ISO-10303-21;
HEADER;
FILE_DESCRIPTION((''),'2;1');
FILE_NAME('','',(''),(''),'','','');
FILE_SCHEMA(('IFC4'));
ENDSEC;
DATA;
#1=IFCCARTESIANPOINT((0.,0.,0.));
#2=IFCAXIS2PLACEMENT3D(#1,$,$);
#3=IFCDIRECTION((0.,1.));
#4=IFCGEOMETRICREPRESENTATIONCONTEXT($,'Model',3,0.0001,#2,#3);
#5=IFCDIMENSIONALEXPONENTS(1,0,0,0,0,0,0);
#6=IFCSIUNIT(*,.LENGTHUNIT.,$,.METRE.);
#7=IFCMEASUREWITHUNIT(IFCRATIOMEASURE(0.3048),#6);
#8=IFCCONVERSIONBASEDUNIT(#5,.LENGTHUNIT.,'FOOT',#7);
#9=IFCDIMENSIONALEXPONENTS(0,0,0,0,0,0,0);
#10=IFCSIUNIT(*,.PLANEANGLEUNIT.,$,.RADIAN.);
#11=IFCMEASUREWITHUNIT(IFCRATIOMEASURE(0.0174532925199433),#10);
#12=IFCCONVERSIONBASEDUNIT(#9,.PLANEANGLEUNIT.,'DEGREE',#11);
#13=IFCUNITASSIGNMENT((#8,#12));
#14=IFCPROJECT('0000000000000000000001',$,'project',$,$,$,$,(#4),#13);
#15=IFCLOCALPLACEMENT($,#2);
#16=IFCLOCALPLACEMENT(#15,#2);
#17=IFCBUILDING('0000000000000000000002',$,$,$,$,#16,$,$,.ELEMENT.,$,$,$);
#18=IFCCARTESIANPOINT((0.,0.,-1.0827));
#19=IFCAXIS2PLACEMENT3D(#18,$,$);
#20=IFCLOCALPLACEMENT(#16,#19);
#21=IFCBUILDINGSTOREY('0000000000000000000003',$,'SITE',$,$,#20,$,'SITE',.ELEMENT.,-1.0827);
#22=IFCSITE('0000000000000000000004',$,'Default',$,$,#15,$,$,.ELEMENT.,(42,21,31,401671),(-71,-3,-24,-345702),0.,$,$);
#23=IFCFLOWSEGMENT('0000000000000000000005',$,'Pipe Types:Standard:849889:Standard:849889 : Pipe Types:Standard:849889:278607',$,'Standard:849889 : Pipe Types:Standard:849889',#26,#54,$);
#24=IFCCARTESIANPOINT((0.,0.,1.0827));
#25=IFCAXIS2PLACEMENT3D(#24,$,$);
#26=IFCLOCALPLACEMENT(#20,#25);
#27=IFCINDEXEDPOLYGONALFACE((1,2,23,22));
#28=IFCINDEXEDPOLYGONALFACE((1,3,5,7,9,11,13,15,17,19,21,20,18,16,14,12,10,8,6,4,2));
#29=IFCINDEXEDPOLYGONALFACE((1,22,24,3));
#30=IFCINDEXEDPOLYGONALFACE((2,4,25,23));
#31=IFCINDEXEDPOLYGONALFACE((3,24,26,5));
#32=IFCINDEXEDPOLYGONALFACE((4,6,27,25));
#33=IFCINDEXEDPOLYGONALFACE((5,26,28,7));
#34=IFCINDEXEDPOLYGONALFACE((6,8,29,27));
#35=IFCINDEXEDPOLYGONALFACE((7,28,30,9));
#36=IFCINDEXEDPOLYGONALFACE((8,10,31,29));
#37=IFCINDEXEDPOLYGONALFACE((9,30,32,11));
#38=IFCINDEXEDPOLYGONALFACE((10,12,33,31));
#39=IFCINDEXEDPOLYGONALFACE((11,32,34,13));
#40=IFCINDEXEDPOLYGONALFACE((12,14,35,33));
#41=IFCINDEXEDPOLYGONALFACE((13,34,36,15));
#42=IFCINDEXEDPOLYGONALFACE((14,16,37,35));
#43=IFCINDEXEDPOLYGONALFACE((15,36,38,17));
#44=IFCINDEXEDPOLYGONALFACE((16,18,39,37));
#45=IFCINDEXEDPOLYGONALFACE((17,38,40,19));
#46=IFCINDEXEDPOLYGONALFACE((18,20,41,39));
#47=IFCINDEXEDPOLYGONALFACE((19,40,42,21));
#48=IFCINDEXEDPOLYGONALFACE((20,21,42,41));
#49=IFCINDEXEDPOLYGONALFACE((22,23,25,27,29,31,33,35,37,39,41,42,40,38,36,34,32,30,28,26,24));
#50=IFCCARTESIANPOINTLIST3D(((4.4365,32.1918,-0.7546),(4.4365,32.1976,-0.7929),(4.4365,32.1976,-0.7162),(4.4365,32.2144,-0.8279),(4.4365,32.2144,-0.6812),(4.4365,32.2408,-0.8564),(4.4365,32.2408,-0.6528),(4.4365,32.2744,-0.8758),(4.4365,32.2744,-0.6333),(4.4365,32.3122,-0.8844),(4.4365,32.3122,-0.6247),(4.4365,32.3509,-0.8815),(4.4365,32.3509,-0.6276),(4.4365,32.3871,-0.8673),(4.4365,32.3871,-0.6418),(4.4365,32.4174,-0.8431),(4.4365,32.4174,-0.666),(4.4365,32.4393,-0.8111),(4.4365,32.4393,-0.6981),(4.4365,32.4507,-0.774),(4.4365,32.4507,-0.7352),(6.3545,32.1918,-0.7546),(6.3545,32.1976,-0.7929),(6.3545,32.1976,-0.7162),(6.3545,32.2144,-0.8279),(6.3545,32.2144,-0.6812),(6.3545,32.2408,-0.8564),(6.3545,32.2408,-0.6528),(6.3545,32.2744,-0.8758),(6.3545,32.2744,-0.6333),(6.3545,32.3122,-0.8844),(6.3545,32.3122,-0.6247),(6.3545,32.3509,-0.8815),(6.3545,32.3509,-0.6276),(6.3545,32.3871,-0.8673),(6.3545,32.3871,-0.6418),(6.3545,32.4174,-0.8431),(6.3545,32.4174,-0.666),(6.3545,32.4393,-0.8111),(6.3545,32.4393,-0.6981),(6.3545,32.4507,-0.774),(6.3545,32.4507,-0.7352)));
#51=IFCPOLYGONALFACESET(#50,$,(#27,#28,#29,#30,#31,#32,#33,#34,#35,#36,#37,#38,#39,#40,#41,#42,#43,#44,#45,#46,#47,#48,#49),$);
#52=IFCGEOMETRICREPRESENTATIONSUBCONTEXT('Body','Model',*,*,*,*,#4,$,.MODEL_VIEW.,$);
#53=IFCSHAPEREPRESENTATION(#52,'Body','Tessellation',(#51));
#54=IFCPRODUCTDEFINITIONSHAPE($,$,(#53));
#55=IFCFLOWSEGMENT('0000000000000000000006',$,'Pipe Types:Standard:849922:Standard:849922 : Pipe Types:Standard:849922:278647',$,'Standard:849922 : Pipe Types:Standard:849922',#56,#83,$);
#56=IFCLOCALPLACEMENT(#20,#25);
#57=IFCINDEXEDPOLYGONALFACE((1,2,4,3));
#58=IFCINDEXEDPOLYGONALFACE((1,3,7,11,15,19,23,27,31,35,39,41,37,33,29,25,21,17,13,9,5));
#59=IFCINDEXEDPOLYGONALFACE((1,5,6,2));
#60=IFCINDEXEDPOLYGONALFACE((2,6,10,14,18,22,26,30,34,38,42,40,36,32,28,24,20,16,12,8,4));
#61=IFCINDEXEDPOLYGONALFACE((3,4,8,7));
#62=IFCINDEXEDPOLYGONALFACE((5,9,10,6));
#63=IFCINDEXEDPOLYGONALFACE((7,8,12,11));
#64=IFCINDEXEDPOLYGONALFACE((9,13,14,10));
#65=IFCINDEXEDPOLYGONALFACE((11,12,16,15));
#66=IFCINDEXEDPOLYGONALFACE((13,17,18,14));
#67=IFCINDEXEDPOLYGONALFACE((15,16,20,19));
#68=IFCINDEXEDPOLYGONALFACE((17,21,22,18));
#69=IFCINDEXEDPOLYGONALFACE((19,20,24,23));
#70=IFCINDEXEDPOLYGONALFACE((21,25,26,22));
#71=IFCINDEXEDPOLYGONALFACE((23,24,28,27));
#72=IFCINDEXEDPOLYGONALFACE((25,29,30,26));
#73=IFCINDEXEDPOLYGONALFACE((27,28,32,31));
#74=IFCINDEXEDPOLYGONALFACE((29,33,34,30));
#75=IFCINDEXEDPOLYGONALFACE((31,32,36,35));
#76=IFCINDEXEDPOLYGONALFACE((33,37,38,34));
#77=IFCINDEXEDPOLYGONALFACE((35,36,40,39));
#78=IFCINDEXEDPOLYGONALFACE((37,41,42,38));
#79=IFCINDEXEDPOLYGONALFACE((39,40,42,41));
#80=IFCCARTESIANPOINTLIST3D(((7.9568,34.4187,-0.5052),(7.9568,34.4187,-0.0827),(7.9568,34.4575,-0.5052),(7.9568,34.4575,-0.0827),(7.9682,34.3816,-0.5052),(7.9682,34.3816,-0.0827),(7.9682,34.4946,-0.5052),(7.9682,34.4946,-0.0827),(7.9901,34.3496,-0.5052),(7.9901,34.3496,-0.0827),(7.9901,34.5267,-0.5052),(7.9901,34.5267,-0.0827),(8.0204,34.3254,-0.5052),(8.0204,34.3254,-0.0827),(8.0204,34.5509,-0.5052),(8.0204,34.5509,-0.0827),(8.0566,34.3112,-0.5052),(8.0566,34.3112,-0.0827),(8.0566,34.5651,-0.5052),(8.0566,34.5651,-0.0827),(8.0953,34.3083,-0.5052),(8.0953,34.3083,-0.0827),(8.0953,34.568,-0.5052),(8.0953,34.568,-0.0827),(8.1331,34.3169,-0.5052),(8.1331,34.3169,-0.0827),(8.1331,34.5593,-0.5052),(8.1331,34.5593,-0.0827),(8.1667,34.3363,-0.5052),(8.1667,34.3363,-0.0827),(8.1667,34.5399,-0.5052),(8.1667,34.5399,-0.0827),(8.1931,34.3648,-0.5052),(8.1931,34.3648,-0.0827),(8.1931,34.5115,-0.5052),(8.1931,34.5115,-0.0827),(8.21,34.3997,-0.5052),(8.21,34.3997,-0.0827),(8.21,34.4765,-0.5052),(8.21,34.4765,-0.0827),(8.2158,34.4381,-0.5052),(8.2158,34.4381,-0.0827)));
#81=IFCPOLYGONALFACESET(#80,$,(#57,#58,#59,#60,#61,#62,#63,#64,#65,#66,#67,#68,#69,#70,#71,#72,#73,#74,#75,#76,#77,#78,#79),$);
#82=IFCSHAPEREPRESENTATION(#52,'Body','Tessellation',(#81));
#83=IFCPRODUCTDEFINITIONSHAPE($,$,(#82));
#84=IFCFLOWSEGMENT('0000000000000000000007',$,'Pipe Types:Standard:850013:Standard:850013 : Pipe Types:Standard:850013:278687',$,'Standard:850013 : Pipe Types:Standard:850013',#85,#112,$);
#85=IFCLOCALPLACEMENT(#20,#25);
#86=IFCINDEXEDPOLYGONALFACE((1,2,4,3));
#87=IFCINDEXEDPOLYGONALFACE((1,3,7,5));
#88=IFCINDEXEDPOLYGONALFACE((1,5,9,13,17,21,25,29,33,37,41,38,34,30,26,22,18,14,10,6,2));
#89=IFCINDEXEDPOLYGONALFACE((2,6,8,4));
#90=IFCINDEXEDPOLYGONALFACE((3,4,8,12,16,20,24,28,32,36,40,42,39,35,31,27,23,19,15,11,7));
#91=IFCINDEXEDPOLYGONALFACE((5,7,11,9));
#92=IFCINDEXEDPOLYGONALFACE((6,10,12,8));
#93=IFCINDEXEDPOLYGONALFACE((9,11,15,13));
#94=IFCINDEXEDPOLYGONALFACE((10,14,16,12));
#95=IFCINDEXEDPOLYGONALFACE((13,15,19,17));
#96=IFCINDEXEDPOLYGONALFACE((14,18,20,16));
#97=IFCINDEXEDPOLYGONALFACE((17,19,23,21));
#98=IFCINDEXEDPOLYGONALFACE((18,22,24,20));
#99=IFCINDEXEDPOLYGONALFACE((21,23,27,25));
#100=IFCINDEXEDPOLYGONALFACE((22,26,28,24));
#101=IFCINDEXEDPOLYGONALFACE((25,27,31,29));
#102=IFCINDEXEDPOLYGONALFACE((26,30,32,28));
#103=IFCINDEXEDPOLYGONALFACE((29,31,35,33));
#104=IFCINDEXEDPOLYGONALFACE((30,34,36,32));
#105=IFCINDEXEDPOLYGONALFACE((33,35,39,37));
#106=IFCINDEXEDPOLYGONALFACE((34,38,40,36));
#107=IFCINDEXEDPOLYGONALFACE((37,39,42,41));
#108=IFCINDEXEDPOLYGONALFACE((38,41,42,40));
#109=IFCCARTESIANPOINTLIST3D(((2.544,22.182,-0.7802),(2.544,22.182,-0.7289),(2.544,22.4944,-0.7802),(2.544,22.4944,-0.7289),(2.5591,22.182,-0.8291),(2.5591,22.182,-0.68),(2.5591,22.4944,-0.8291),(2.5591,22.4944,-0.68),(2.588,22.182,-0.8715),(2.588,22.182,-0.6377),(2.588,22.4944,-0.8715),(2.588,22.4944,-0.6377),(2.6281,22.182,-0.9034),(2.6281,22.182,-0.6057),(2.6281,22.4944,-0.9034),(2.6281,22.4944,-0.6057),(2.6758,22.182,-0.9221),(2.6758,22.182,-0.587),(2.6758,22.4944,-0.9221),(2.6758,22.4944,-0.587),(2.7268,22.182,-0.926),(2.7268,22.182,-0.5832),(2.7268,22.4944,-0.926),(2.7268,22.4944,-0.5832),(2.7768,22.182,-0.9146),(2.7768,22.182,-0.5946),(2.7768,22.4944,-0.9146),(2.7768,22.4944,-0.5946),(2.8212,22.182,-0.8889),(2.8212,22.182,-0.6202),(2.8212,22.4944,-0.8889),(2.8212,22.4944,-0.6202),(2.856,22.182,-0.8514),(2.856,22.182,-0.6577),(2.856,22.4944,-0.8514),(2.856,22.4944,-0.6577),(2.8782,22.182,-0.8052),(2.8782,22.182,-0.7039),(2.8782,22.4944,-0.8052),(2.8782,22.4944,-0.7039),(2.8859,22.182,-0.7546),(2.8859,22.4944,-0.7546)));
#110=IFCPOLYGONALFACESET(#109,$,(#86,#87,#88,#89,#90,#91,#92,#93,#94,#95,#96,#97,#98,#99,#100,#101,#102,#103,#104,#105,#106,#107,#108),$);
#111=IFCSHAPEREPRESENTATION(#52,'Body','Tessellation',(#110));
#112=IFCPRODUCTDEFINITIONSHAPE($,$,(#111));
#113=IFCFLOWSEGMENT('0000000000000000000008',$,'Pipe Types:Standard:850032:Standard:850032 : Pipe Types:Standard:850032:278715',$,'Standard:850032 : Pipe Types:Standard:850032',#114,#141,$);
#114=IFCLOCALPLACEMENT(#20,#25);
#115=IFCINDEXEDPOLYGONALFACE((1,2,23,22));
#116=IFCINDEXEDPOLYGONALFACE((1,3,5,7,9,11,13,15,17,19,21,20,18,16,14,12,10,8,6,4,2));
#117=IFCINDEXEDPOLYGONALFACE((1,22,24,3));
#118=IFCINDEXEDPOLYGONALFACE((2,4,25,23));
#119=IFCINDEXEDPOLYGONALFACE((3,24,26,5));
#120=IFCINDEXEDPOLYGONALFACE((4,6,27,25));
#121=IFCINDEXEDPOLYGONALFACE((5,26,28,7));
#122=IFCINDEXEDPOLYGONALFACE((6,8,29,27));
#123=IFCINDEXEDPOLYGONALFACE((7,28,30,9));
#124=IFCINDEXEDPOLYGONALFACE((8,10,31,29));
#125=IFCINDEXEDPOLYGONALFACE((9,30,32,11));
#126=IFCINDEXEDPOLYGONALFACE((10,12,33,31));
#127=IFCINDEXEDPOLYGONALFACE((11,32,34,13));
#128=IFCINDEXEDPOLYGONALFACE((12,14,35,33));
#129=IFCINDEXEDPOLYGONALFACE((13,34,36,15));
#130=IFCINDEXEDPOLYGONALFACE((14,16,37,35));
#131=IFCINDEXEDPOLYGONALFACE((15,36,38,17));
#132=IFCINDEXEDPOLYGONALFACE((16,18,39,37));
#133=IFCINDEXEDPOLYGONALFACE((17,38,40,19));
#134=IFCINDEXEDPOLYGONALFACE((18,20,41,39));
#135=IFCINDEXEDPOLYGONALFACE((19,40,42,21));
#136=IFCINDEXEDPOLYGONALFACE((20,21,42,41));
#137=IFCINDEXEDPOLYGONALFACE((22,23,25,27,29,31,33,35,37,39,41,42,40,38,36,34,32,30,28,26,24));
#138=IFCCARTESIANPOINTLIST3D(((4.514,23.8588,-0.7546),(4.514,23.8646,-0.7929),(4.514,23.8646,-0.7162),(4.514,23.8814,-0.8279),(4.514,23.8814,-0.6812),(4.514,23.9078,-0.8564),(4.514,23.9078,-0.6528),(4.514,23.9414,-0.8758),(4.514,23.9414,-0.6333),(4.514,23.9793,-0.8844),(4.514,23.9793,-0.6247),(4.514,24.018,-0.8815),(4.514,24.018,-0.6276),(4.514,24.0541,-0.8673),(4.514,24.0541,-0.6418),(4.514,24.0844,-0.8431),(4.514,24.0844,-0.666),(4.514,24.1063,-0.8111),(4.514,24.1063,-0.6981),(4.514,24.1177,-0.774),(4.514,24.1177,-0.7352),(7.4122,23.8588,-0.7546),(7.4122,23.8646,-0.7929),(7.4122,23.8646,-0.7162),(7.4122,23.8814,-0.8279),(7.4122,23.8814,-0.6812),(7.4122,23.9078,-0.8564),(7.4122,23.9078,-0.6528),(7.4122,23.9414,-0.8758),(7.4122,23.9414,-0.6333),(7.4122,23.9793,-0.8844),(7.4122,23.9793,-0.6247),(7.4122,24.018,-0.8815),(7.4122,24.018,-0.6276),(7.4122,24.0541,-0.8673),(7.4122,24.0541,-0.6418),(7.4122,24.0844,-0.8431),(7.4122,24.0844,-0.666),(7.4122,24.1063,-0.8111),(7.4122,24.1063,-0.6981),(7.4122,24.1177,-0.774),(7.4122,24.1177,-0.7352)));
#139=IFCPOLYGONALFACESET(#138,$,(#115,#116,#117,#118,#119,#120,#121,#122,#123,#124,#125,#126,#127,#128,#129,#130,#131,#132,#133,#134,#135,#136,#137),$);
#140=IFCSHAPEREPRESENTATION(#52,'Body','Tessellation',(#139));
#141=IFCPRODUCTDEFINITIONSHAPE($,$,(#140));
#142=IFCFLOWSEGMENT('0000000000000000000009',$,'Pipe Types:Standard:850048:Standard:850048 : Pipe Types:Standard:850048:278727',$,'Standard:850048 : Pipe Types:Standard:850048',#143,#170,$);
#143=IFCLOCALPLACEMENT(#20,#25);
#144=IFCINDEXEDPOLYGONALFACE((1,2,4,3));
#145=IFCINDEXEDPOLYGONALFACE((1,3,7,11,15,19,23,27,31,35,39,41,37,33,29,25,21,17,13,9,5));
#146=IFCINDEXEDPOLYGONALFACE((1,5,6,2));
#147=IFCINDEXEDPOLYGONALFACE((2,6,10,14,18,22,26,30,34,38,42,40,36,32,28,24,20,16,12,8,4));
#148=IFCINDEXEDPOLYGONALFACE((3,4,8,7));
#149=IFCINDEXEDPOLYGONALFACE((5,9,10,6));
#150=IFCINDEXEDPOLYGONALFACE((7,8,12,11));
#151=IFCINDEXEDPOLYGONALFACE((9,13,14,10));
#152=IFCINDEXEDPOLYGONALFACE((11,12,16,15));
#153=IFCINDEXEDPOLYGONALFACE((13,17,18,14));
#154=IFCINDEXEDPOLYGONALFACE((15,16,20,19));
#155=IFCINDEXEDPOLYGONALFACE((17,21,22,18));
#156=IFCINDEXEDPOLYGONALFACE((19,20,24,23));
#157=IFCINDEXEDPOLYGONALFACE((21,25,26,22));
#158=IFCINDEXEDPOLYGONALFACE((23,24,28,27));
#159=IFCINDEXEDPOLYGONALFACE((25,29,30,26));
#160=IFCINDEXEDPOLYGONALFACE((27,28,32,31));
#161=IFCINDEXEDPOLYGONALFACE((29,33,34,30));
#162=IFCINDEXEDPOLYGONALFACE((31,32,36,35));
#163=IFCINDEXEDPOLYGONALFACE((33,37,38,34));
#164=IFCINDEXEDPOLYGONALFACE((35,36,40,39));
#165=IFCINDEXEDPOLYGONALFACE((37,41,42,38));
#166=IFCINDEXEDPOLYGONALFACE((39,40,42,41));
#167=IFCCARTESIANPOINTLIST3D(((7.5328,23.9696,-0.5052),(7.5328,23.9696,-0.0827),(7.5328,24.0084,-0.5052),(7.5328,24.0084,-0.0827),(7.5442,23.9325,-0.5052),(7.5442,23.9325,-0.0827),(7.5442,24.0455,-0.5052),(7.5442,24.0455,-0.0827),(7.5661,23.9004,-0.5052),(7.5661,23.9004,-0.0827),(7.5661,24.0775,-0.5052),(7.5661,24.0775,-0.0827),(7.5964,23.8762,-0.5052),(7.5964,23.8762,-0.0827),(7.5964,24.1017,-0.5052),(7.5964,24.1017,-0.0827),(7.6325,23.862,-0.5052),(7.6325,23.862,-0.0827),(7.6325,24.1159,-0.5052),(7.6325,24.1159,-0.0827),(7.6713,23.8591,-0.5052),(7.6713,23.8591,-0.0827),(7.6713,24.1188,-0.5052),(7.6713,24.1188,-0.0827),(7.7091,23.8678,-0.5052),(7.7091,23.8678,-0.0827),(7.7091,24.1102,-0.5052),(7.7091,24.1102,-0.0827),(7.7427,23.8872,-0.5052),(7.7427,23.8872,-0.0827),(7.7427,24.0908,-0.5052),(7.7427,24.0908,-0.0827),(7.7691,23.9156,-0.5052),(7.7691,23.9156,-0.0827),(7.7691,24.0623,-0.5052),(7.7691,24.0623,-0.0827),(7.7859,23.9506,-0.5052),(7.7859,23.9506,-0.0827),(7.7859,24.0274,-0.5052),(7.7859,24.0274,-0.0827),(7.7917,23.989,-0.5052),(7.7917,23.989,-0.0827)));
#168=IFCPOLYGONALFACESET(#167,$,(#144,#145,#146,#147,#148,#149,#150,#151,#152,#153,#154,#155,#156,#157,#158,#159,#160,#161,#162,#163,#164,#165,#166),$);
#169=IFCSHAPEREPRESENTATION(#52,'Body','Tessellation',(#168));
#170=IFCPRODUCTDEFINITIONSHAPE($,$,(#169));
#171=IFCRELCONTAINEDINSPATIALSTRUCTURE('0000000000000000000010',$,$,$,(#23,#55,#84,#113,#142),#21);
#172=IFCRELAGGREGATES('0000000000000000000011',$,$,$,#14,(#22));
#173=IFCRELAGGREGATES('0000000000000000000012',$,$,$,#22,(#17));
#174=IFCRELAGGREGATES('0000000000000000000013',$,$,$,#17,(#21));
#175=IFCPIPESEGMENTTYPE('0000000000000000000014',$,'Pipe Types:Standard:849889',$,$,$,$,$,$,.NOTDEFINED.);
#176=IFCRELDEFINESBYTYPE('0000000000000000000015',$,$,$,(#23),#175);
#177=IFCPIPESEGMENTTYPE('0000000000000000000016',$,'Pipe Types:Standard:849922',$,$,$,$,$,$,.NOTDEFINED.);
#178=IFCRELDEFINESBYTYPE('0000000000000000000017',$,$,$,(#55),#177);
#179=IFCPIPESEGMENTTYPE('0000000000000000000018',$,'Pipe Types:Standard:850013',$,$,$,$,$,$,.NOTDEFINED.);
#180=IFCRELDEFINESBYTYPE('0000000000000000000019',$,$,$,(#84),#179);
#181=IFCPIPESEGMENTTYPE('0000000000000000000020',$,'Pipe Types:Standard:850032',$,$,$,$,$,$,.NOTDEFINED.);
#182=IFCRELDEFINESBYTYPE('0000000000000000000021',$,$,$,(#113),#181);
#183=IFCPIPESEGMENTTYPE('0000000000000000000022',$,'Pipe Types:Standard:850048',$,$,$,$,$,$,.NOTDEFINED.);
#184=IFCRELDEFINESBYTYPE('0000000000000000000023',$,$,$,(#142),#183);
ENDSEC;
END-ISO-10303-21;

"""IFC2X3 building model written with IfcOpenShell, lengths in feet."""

from ifc_helpers import new_model, entity, si_unit, converted_unit, direction, frame, frame_2d, origin, origin_2d_with_axis, place, context, subcontext, project, spatial, circle, extrude, source, transform, mapped, type_object, type_shapes, element, save


model = new_model("IFC2X3")

# Units and contexts
model_context = context("Model", 3, precision=0.0001, world=origin(), true_north=direction((0.0, 1.0)))
body_context = subcontext(model_context, "Body", "Model", "MODEL_VIEW")
ifc_project = project(units=[converted_unit("LENGTHUNIT", "FOOT", entity("IfcRatioMeasure", 0.3048), si_unit("LENGTHUNIT", "METRE"), dimensions=[1, 0, 0, 0, 0, 0, 0]), converted_unit("PLANEANGLEUNIT", "DEGREE", entity("IfcRatioMeasure", 0.0174532925199433), si_unit("PLANEANGLEUNIT", "RADIAN"), dimensions=[0, 0, 0, 0, 0, 0, 0])], contexts=[model_context])

# Site, building, storey
site_placement = place(None, origin())
site = spatial("IfcSite", under=ifc_project, at=site_placement, Name="Default", CompositionType="ELEMENT", RefLatitude=(42, 21, 31, 401671), RefLongitude=(-71, -3, -24, -345702), RefElevation=0.0)
building_placement = place(site_placement, origin())
building = spatial("IfcBuilding", under=site, at=building_placement, CompositionType="ELEMENT")
storey_placement = place(building_placement, frame((0.0, 0.0, -1.0827)))
storey = spatial("IfcBuildingStorey", under=building, at=storey_placement, Name="SITE", LongName="SITE", CompositionType="ELEMENT", Elevation=-1.0827)

# Flow segments
pipe_segment_type_1 = type_object("IfcPipeSegmentType", Name="Pipe Types:Standard:849889", PredefinedType="NOTDEFINED")
shared_shape_1 = source(origin(), body_context, "Body", "SweptSolid", [
    extrude(circle(Radius=0.1302, at=frame_2d((0.0, 0.0), x_axis=(1.0, 0.0))), frame((4.4365, 32.322, -0.7546), z_axis=(1.0, 0.0, 0.0), x_axis=(0.0, -1.0, 0.0)), (0.0, 0.0, 1.0), 1.918),
])
type_shapes(pipe_segment_type_1, [shared_shape_1])
flow_segment_1_placement = place(storey_placement, frame((0.0, 0.0, 1.0827)))
element("IfcFlowSegment", 1, at=flow_segment_1_placement, inside=storey, type_object=pipe_segment_type_1, Name="Pipe Types:Standard:849889:Standard:849889 : Pipe Types:Standard:849889:278607", ObjectType="Standard:849889 : Pipe Types:Standard:849889", context=body_context, shape_type="MappedRepresentation", body=[
    mapped(shared_shape_1, transform((0.0, 0.0, 0.0), scale=1.0)),
])
pipe_segment_type_2 = type_object("IfcPipeSegmentType", Name="Pipe Types:Standard:849922", PredefinedType="NOTDEFINED")
shared_shape_2 = source(origin(), body_context, "Body", "SweptSolid", [
    extrude(circle(Radius=0.1302, at=origin_2d_with_axis()), frame((8.0855, 34.4381, -0.5052)), (0.0, 0.0, 1.0), 0.4225),
])
type_shapes(pipe_segment_type_2, [shared_shape_2])
flow_segment_2_placement = place(storey_placement, frame((0.0, 0.0, 1.0827)))
element("IfcFlowSegment", 2, at=flow_segment_2_placement, inside=storey, type_object=pipe_segment_type_2, Name="Pipe Types:Standard:849922:Standard:849922 : Pipe Types:Standard:849922:278647", ObjectType="Standard:849922 : Pipe Types:Standard:849922", context=body_context, shape_type="MappedRepresentation", body=[
    mapped(shared_shape_2, transform((0.0, 0.0, 0.0), scale=1.0)),
])
pipe_segment_type_3 = type_object("IfcPipeSegmentType", Name="Pipe Types:Standard:850013", PredefinedType="NOTDEFINED")
shared_shape_3 = source(origin(), body_context, "Body", "SweptSolid", [
    extrude(circle(Radius=0.1719, at=frame_2d((0.0, 0.0), x_axis=(1.0, 0.0))), frame((2.714, 22.182, -0.7546), z_axis=(0.0, 1.0, 0.0), x_axis=(1.0, 0.0, 0.0)), (0.0, 0.0, 1.0), 0.3124),
])
type_shapes(pipe_segment_type_3, [shared_shape_3])
flow_segment_3_placement = place(storey_placement, frame((0.0, 0.0, 1.0827)))
element("IfcFlowSegment", 3, at=flow_segment_3_placement, inside=storey, type_object=pipe_segment_type_3, Name="Pipe Types:Standard:850013:Standard:850013 : Pipe Types:Standard:850013:278687", ObjectType="Standard:850013 : Pipe Types:Standard:850013", context=body_context, shape_type="MappedRepresentation", body=[
    mapped(shared_shape_3, transform((0.0, 0.0, 0.0), scale=1.0)),
])
pipe_segment_type_4 = type_object("IfcPipeSegmentType", Name="Pipe Types:Standard:850032", PredefinedType="NOTDEFINED")
shared_shape_4 = source(origin(), body_context, "Body", "SweptSolid", [
    extrude(circle(Radius=0.1302, at=frame_2d((0.0, 0.0), x_axis=(1.0, 0.0))), frame((4.514, 23.989, -0.7546), z_axis=(1.0, 0.0, 0.0), x_axis=(0.0, -1.0, 0.0)), (0.0, 0.0, 1.0), 2.8982),
])
type_shapes(pipe_segment_type_4, [shared_shape_4])
flow_segment_4_placement = place(storey_placement, frame((0.0, 0.0, 1.0827)))
element("IfcFlowSegment", 4, at=flow_segment_4_placement, inside=storey, type_object=pipe_segment_type_4, Name="Pipe Types:Standard:850032:Standard:850032 : Pipe Types:Standard:850032:278715", ObjectType="Standard:850032 : Pipe Types:Standard:850032", context=body_context, shape_type="MappedRepresentation", body=[
    mapped(shared_shape_4, transform((0.0, 0.0, 0.0), scale=1.0)),
])
pipe_segment_type_5 = type_object("IfcPipeSegmentType", Name="Pipe Types:Standard:850048", PredefinedType="NOTDEFINED")
shared_shape_5 = source(origin(), body_context, "Body", "SweptSolid", [
    extrude(circle(Radius=0.1302, at=origin_2d_with_axis()), frame((7.6615, 23.989, -0.5052)), (0.0, 0.0, 1.0), 0.4225),
])
type_shapes(pipe_segment_type_5, [shared_shape_5])
flow_segment_5_placement = place(storey_placement, frame((0.0, 0.0, 1.0827)))
element("IfcFlowSegment", 5, at=flow_segment_5_placement, inside=storey, type_object=pipe_segment_type_5, Name="Pipe Types:Standard:850048:Standard:850048 : Pipe Types:Standard:850048:278727", ObjectType="Standard:850048 : Pipe Types:Standard:850048", context=body_context, shape_type="MappedRepresentation", body=[
    mapped(shared_shape_5, transform((0.0, 0.0, 0.0), scale=1.0)),
])

save(model, "model.ifc")
